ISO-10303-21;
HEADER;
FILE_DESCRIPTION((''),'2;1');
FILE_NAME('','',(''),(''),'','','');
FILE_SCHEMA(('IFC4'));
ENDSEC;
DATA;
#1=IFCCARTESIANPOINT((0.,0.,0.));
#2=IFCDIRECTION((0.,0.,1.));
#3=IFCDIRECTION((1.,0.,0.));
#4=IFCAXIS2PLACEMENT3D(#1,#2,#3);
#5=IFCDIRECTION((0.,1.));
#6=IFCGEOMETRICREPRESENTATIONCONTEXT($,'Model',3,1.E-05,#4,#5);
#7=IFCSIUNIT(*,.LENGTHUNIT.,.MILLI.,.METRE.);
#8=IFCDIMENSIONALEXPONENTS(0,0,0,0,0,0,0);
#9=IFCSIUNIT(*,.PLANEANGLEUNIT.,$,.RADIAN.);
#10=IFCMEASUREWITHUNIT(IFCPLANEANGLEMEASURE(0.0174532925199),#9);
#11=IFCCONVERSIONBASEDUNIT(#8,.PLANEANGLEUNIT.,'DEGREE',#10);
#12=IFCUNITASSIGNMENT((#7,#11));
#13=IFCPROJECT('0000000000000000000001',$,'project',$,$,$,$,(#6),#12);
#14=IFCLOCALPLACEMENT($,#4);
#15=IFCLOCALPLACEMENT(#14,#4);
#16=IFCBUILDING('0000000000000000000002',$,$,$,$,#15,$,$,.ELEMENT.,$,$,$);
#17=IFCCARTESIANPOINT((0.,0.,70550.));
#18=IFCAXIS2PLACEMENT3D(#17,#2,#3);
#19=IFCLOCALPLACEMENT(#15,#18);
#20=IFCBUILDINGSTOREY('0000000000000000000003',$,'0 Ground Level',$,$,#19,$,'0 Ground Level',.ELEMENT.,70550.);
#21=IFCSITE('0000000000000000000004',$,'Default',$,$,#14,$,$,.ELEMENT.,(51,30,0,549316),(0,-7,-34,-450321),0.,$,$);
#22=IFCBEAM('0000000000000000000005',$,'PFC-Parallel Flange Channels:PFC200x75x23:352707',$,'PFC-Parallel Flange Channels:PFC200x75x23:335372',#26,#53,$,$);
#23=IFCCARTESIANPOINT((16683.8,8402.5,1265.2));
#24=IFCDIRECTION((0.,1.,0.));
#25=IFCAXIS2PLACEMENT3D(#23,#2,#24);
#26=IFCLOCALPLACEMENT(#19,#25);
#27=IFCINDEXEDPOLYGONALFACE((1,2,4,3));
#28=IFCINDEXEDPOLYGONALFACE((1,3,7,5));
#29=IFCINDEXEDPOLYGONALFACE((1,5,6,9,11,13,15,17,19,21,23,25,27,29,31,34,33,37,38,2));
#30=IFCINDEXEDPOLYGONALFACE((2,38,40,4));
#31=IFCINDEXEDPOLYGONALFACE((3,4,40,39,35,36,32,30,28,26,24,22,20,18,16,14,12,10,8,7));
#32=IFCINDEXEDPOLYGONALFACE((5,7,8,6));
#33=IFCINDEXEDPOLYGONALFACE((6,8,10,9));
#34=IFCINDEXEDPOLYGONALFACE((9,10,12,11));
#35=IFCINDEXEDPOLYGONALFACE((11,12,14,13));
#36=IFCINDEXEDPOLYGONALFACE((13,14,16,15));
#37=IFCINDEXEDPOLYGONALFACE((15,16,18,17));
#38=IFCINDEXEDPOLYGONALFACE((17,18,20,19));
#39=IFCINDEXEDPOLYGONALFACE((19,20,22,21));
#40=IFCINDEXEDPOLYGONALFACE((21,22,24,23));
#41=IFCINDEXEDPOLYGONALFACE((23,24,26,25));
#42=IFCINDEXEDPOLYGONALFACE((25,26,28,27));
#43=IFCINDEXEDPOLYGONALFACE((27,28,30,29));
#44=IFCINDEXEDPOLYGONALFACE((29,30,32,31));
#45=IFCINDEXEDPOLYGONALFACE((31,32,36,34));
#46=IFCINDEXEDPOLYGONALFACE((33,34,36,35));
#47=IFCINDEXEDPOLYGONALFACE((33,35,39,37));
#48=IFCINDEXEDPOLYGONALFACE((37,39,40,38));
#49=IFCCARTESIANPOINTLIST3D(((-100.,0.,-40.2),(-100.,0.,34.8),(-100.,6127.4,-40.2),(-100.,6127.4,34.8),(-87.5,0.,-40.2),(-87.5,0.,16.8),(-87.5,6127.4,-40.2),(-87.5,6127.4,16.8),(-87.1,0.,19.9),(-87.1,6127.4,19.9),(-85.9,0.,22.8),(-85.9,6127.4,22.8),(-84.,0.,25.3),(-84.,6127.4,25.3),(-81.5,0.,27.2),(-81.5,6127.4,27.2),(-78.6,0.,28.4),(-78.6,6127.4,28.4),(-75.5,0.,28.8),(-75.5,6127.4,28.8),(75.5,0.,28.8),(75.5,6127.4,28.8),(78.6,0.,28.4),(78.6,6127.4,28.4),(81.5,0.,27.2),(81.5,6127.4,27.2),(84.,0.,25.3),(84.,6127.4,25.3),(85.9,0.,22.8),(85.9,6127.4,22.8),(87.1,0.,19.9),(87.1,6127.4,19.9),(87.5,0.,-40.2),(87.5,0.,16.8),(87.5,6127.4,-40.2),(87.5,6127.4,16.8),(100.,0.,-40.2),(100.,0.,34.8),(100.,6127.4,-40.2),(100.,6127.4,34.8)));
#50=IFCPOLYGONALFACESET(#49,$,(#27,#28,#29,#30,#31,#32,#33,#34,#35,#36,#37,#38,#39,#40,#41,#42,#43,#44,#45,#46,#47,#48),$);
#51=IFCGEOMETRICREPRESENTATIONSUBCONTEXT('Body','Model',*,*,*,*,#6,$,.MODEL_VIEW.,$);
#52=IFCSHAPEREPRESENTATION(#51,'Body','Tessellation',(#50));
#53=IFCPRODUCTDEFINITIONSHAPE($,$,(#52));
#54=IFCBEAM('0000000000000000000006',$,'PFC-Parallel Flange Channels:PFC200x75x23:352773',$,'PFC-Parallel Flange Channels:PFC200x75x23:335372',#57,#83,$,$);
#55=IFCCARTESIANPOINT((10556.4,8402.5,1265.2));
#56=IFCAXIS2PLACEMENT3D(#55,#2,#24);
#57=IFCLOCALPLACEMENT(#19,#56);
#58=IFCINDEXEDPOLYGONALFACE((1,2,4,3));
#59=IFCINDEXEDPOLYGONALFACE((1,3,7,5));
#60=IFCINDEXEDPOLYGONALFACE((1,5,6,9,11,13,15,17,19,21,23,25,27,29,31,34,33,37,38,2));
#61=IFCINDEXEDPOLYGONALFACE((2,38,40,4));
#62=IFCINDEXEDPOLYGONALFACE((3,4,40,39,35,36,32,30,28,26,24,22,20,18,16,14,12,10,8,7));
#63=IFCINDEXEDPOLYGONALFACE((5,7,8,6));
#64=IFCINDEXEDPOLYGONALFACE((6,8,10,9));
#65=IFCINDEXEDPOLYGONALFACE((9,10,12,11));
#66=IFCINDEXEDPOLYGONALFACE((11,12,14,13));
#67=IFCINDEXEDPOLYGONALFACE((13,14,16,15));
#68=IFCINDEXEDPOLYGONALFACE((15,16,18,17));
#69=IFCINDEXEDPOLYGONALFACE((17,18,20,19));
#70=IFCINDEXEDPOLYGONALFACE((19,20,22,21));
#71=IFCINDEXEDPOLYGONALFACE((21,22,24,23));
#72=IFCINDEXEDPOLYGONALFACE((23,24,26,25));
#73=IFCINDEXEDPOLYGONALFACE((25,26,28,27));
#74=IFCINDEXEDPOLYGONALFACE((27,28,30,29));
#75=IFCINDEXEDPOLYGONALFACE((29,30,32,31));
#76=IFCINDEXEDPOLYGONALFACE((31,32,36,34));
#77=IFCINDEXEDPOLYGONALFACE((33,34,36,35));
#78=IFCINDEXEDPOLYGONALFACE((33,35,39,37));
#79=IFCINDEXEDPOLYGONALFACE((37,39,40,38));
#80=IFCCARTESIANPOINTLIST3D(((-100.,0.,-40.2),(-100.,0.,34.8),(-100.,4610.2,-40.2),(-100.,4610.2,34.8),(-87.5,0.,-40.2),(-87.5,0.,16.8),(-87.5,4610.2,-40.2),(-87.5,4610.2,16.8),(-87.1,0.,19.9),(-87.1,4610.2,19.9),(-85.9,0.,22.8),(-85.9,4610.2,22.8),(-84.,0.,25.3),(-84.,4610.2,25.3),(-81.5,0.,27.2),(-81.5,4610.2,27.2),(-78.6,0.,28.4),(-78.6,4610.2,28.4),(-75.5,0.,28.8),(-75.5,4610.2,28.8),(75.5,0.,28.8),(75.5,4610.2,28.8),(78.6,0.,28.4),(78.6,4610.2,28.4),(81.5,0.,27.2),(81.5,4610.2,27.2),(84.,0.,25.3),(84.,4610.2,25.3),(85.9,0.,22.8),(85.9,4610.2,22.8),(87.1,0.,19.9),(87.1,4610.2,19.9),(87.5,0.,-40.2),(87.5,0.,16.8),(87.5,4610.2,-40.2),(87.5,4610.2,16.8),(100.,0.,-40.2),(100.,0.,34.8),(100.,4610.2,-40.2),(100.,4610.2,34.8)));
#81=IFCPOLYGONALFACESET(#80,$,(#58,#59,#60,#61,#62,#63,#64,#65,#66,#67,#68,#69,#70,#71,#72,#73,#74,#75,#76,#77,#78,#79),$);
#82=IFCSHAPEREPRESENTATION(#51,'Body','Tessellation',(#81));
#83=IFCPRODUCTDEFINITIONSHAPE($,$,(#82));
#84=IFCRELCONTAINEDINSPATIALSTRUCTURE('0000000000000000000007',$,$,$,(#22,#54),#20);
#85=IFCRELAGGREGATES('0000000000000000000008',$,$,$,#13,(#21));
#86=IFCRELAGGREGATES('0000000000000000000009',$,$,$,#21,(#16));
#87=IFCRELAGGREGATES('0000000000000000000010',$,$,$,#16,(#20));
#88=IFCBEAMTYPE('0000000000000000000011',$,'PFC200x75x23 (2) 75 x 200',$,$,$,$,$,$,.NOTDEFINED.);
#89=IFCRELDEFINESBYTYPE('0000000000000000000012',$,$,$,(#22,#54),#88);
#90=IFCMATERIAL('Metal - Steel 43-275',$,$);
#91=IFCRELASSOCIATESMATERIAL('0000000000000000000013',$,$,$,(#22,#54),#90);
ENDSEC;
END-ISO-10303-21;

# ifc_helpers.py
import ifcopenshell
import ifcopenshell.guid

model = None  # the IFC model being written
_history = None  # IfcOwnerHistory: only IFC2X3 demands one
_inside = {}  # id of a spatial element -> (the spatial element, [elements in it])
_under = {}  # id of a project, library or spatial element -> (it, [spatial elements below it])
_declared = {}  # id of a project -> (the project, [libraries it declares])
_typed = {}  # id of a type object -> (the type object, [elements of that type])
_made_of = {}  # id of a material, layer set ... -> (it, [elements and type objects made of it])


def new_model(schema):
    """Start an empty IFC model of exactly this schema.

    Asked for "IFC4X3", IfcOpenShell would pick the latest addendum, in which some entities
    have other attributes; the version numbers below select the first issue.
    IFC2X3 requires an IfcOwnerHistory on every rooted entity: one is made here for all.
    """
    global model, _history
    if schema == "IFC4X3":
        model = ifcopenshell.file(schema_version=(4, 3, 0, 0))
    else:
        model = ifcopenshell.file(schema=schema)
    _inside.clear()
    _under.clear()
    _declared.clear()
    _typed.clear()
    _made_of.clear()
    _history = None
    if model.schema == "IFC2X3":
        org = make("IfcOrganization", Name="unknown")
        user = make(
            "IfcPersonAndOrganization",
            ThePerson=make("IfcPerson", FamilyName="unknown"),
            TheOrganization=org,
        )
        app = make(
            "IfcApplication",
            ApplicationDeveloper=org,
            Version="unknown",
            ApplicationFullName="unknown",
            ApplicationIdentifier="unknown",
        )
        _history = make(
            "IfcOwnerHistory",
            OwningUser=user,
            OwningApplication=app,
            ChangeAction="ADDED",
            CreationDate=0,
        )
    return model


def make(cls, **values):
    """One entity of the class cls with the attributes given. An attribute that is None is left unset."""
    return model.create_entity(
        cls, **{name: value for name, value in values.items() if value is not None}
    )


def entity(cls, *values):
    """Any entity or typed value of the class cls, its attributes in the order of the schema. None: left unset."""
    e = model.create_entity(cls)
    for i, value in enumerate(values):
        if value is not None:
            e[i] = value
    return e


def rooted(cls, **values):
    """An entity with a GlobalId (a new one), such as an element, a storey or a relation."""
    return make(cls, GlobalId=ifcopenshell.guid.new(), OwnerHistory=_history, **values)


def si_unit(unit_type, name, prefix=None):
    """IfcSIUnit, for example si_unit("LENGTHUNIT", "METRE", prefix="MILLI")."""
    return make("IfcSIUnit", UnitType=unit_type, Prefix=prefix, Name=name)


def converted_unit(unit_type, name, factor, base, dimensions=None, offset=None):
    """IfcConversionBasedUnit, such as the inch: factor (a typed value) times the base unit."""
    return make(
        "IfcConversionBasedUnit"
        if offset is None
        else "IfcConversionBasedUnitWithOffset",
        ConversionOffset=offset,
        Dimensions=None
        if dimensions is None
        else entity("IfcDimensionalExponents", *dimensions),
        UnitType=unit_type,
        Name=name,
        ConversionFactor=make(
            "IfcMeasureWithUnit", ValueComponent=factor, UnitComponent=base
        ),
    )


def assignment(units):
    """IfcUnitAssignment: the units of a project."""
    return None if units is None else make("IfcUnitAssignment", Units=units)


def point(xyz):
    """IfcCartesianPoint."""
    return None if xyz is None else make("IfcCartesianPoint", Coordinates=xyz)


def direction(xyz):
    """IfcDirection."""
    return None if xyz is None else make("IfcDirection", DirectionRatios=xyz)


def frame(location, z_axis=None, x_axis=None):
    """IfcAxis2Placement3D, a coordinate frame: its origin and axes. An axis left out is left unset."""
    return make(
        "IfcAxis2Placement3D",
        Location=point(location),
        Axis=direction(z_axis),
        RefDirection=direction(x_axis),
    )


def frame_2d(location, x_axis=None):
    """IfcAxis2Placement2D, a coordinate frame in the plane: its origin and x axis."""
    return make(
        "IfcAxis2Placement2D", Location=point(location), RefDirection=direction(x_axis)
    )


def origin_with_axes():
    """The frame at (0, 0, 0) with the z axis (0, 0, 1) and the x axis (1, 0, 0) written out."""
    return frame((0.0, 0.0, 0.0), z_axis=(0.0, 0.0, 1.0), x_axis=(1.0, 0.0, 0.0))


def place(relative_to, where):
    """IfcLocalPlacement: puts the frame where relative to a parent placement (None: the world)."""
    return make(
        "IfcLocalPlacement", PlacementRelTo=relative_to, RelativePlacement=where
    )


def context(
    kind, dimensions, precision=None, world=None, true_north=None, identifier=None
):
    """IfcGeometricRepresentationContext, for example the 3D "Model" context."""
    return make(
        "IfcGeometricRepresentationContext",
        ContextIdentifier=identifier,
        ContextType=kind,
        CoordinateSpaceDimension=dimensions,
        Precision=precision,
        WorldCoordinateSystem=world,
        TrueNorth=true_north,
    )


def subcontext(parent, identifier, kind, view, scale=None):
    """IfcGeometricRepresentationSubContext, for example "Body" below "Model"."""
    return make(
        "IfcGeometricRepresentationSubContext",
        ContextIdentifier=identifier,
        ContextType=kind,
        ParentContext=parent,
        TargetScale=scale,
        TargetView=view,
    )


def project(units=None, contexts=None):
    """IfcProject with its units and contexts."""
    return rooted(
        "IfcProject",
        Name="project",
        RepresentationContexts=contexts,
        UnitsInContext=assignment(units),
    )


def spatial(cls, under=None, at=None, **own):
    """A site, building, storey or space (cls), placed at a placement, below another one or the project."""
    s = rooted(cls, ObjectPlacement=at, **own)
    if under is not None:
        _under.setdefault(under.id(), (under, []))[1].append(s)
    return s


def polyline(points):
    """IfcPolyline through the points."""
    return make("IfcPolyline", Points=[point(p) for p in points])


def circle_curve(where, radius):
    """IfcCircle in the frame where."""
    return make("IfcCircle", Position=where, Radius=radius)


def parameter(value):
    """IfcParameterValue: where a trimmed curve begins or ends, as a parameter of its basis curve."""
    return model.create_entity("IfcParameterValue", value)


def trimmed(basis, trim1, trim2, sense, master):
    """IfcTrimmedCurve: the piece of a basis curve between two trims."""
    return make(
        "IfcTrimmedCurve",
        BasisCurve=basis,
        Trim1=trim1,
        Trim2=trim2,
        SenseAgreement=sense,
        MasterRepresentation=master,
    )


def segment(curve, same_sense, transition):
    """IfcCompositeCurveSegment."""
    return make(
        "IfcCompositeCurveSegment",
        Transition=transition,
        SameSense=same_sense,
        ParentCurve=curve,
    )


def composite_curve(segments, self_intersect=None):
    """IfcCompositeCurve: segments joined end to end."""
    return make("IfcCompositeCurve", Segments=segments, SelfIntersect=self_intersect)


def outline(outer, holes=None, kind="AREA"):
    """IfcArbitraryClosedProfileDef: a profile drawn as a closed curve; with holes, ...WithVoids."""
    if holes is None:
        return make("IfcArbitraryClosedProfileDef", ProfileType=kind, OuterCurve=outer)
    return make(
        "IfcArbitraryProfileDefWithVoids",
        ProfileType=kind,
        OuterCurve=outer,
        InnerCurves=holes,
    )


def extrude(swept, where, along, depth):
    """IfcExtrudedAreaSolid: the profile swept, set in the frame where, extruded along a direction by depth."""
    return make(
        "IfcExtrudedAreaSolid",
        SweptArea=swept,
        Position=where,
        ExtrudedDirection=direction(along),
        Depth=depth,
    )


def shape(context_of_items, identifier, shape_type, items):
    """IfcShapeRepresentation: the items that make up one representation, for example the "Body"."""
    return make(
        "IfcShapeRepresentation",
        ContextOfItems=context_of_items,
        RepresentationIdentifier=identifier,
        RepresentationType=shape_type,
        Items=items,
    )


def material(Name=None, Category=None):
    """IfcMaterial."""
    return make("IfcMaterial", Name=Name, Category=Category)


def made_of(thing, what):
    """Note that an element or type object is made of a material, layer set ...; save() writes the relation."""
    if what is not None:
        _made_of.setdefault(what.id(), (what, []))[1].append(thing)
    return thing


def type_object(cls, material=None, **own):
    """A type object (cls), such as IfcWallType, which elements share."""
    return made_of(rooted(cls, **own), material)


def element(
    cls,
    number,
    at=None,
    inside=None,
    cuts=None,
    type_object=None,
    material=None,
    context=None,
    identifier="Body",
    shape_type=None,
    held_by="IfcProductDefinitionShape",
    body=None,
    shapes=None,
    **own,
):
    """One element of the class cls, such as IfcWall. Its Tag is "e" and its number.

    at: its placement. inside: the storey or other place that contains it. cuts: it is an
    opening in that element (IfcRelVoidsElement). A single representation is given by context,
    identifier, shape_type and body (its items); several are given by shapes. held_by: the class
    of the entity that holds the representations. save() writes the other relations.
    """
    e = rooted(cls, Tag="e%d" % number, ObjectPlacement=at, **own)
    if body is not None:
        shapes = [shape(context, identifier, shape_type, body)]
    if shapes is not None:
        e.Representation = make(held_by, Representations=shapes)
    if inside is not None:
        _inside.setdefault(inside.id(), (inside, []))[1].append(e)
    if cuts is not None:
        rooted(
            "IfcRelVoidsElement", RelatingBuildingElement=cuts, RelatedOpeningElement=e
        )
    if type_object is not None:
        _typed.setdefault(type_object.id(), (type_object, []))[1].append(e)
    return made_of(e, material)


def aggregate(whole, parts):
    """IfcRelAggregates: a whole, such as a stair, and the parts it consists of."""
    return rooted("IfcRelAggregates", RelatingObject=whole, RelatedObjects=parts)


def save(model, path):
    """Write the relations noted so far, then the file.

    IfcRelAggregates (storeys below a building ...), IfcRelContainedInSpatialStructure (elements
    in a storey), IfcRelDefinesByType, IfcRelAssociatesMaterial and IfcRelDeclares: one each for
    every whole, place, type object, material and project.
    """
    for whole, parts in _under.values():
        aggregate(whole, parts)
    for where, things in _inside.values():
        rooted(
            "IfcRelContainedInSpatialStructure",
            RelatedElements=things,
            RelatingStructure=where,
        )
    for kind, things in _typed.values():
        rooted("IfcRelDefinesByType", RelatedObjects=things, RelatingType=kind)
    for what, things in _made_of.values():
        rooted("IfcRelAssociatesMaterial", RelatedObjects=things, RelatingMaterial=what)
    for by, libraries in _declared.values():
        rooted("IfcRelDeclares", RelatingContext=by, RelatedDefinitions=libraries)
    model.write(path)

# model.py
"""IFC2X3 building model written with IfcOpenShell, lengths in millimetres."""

from ifc_helpers import new_model, entity, si_unit, converted_unit, point, direction, frame, frame_2d, origin_with_axes, place, context, subcontext, project, spatial, polyline, circle_curve, parameter, trimmed, segment, composite_curve, outline, extrude, material, type_object, element, save


model = new_model("IFC2X3")

# Units and contexts
model_context = context("Model", 3, precision=1e-05, world=origin_with_axes(), true_north=direction((0.0, 1.0)))
body_context = subcontext(model_context, "Body", "Model", "MODEL_VIEW")
ifc_project = project(units=[si_unit("LENGTHUNIT", "METRE", prefix="MILLI"), converted_unit("PLANEANGLEUNIT", "DEGREE", entity("IfcPlaneAngleMeasure", 0.0174532925199), si_unit("PLANEANGLEUNIT", "RADIAN"), dimensions=[0, 0, 0, 0, 0, 0, 0])], contexts=[model_context])

# Site, building, storey
site_placement = place(None, origin_with_axes())
site = spatial("IfcSite", under=ifc_project, at=site_placement, Name="Default", CompositionType="ELEMENT", RefLatitude=(51, 30, 0, 549316), RefLongitude=(0, -7, -34, -450321), RefElevation=0.0)
building_placement = place(site_placement, origin_with_axes())
building = spatial("IfcBuilding", under=site, at=building_placement, CompositionType="ELEMENT")
storey_placement = place(building_placement, frame((0.0, 0.0, 70550.0), z_axis=(0.0, 0.0, 1.0), x_axis=(1.0, 0.0, 0.0)))
storey = spatial("IfcBuildingStorey", under=building, at=storey_placement, Name="0 Ground Level", LongName="0 Ground Level", CompositionType="ELEMENT", Elevation=70550.0)

# Beams
ifc_material = material(Name="Metal - Steel 43-275")
beam_type_1 = type_object("IfcBeamType", Name="PFC200x75x23 (2) 75 x 200", PredefinedType="NOTDEFINED")
beam_1_placement = place(storey_placement, frame((16683.8, 8402.5, 1265.2), z_axis=(0.0, 0.0, 1.0), x_axis=(0.0, 1.0, 0.0)))
element("IfcBeam", 1, at=beam_1_placement, inside=storey, type_object=beam_type_1, material=ifc_material, Name="PFC-Parallel Flange Channels:PFC200x75x23:352707", ObjectType="PFC-Parallel Flange Channels:PFC200x75x23:335372", context=body_context, shape_type="SweptSolid", body=[
    extrude(outline(composite_curve([segment(polyline([(-34.8, -100.0), (40.2, -100.0), (40.2, -87.5), (-16.8, -87.5)]), True, "CONTINUOUS"), segment(trimmed(circle_curve(frame_2d((-16.8, -75.5), x_axis=(-1.0, 0.0)), 12.0), [point((-16.8, -87.5)), parameter(90.0)], [point((-28.8, -75.5)), parameter(0.0)], False, "CARTESIAN"), True, "CONTINUOUS"), segment(polyline([(-28.8, -75.5), (-28.8, 75.5)]), True, "CONTINUOUS"), segment(trimmed(circle_curve(frame_2d((-16.8, 75.5), x_axis=(0.0, 1.0)), 12.0), [point((-28.8, 75.5)), parameter(90.0)], [point((-16.8, 87.5)), parameter(0.0)], False, "CARTESIAN"), True, "CONTINUOUS"), segment(polyline([(-16.8, 87.5), (40.2, 87.5), (40.2, 100.0), (-34.8, 100.0), (-34.8, -100.0)]), True, "CONTINUOUS")], self_intersect=False)), frame((0.0, 6127.4, 0.0), z_axis=(0.0, -1.0, 0.0), x_axis=(0.0, 0.0, -1.0)), (0.0, 0.0, 1.0), 6127.4),
])
beam_2_placement = place(storey_placement, frame((10556.4, 8402.5, 1265.2), z_axis=(0.0, 0.0, 1.0), x_axis=(0.0, 1.0, 0.0)))
element("IfcBeam", 2, at=beam_2_placement, inside=storey, type_object=beam_type_1, material=ifc_material, Name="PFC-Parallel Flange Channels:PFC200x75x23:352773", ObjectType="PFC-Parallel Flange Channels:PFC200x75x23:335372", context=body_context, shape_type="SweptSolid", body=[
    extrude(outline(composite_curve([segment(polyline([(-34.8, -100.0), (40.2, -100.0), (40.2, -87.5), (-16.8, -87.5)]), True, "CONTINUOUS"), segment(trimmed(circle_curve(frame_2d((-16.8, -75.5), x_axis=(-1.0, 0.0)), 12.0), [point((-16.8, -87.5)), parameter(90.0)], [point((-28.8, -75.5)), parameter(0.0)], False, "CARTESIAN"), True, "CONTINUOUS"), segment(polyline([(-28.8, -75.5), (-28.8, 75.5)]), True, "CONTINUOUS"), segment(trimmed(circle_curve(frame_2d((-16.8, 75.5), x_axis=(0.0, 1.0)), 12.0), [point((-28.8, 75.5)), parameter(90.0)], [point((-16.8, 87.5)), parameter(0.0)], False, "CARTESIAN"), True, "CONTINUOUS"), segment(polyline([(-16.8, 87.5), (40.2, 87.5), (40.2, 100.0), (-34.8, 100.0), (-34.8, -100.0)]), True, "CONTINUOUS")], self_intersect=False)), frame((0.0, 4610.2, 0.0), z_axis=(0.0, -1.0, 0.0), x_axis=(0.0, 0.0, -1.0)), (0.0, 0.0, 1.0), 4610.2),
])

save(model, "model.ifc")
